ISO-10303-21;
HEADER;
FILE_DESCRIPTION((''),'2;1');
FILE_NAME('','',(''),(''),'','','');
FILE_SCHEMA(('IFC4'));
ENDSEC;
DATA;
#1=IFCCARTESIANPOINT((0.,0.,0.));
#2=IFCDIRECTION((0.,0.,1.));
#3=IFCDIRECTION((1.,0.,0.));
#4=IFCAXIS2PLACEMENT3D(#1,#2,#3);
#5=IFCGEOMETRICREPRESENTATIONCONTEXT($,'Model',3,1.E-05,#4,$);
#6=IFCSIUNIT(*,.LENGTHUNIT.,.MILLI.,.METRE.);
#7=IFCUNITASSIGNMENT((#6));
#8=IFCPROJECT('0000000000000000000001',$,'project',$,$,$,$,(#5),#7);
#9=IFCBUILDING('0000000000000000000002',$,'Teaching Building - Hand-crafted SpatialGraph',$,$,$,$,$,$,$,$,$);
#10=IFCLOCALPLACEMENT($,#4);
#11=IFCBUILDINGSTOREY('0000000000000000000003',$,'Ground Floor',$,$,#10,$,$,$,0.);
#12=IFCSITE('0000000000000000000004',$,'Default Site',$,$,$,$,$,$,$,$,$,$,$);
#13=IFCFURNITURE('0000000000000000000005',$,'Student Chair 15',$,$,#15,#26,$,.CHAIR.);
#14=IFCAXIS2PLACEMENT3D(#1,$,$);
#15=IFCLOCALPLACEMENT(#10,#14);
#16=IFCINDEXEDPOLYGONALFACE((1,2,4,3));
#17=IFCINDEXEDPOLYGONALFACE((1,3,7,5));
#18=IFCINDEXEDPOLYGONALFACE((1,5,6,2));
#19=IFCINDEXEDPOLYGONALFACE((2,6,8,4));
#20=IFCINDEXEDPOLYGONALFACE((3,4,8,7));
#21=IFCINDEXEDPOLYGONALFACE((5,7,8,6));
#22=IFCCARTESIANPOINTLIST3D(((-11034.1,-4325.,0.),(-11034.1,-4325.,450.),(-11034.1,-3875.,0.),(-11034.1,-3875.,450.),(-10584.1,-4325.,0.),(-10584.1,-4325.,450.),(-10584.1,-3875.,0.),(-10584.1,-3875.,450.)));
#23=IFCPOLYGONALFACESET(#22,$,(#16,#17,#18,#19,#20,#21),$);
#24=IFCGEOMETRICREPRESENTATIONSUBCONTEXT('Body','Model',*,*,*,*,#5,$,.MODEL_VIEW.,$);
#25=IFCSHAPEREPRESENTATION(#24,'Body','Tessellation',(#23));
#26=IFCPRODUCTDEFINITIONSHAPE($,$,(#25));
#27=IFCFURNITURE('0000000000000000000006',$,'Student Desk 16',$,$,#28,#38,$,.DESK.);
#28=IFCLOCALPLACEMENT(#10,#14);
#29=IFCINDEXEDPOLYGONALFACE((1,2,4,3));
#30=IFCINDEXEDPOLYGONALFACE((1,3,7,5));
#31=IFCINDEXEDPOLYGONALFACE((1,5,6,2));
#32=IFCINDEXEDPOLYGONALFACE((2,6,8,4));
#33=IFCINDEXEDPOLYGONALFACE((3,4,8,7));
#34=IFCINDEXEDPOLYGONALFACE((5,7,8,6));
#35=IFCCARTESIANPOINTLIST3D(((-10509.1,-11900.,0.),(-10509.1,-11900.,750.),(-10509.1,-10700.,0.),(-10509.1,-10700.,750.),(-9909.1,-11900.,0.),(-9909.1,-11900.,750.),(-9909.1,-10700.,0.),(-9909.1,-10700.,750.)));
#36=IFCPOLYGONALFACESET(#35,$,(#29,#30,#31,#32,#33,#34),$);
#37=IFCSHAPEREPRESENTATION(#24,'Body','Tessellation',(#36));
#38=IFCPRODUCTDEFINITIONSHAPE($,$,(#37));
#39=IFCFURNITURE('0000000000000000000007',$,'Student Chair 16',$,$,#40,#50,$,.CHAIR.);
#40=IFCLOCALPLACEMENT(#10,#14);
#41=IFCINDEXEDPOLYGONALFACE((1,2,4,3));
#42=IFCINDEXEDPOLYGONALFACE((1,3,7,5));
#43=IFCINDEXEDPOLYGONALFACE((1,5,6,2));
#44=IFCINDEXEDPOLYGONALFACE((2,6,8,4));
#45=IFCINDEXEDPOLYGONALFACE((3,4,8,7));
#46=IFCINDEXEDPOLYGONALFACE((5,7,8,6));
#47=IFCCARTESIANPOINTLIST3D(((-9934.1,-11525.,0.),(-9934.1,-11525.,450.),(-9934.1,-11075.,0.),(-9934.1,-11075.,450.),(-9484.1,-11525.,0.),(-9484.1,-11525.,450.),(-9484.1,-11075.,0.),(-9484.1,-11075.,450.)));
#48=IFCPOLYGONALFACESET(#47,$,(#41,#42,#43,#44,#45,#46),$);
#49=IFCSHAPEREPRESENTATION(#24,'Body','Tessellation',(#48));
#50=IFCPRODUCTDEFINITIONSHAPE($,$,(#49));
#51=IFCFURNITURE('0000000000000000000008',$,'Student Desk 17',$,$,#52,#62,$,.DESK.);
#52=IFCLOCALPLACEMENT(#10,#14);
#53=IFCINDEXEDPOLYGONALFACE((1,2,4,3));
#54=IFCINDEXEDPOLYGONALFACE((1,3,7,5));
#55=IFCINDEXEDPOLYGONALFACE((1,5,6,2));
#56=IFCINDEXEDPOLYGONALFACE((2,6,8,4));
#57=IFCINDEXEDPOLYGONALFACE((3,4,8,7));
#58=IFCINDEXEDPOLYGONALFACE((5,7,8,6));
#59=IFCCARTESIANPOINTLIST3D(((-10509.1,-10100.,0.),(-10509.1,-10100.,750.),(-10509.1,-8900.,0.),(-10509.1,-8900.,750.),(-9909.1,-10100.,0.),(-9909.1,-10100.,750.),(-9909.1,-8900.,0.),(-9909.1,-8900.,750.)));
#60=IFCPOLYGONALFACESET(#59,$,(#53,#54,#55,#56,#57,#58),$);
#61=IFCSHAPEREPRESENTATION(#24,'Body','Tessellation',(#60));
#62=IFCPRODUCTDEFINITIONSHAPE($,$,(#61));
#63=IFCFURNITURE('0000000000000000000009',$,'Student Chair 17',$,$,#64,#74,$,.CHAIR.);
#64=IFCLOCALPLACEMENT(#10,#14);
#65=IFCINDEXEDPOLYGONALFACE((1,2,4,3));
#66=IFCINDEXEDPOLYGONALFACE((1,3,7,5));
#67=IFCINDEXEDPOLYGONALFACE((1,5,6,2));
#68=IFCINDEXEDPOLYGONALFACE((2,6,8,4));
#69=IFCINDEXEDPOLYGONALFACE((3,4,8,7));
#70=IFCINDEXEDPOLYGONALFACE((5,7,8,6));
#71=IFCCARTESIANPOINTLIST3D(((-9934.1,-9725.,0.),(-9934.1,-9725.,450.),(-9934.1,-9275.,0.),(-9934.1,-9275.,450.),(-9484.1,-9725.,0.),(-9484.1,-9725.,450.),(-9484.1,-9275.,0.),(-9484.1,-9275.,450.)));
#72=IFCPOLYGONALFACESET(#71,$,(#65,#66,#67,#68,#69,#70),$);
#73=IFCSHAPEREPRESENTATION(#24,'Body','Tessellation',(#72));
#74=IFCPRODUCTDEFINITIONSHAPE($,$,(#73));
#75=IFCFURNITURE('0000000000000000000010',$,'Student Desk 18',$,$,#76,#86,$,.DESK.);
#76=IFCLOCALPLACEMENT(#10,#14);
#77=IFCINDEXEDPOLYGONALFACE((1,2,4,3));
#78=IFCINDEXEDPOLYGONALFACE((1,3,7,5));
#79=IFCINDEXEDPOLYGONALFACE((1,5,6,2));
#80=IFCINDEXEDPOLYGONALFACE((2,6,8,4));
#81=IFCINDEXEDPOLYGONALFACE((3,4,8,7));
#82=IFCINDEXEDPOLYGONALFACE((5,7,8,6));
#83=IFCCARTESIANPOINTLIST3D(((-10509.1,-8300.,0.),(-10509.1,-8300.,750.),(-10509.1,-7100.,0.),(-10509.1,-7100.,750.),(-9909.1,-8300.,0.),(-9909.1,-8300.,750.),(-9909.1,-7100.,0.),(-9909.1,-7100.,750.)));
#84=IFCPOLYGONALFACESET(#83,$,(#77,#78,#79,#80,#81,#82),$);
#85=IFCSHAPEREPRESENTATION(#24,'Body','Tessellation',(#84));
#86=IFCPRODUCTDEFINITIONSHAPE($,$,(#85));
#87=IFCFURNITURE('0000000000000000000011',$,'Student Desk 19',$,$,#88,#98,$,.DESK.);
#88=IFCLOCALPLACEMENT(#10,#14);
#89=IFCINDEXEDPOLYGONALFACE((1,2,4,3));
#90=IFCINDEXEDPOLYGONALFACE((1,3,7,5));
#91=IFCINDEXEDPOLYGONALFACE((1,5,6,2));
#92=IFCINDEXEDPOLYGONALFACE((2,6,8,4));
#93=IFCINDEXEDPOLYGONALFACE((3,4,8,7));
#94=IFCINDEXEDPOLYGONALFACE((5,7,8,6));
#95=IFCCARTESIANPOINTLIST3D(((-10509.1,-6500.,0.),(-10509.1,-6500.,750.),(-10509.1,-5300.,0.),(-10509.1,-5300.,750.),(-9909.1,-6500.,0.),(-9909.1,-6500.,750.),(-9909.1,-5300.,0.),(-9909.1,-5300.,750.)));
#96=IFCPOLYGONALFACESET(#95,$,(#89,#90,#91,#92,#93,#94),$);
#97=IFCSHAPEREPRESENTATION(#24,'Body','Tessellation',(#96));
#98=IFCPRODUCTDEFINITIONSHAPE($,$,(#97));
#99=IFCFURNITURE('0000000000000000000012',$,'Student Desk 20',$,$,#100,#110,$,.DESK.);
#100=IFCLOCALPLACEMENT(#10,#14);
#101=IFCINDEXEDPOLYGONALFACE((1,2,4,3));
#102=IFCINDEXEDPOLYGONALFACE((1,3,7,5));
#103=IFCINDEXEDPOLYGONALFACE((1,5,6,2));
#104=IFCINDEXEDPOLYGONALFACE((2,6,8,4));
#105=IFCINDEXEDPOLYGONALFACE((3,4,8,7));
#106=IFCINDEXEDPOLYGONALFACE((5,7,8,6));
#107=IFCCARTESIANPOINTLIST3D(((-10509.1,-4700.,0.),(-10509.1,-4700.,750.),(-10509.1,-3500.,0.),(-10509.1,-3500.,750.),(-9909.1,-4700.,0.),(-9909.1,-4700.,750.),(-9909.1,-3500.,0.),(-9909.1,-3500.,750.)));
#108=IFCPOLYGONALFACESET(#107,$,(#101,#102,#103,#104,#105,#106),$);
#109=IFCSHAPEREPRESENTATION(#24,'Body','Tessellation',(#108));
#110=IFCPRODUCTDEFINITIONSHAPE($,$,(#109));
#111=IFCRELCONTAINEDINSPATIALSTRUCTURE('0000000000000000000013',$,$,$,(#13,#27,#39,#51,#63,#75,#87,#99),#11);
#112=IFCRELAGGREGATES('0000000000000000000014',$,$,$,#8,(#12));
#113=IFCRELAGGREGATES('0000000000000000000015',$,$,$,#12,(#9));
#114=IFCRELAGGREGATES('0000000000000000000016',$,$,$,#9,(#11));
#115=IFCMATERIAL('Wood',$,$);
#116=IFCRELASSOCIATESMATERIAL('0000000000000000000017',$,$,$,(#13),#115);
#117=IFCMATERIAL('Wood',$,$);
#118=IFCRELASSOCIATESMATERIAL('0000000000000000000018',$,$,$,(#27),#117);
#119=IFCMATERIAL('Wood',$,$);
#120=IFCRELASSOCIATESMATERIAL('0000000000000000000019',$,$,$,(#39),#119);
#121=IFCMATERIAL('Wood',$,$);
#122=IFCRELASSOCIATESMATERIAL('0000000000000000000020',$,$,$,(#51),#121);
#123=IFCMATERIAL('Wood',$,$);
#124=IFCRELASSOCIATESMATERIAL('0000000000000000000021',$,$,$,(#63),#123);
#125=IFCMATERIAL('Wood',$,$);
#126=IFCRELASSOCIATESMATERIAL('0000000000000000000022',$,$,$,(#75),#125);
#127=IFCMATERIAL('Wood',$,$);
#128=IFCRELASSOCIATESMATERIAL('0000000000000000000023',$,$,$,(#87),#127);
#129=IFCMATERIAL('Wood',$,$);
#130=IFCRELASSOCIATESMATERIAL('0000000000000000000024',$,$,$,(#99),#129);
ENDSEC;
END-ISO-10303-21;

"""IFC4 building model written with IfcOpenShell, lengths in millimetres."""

from ifc_helpers import new_model, si_unit, frame, origin_with_axes, origin_2d, place, context, subcontext, project, spatial, rectangle, extrude, material, element, save


model = new_model("IFC4")

# Units and contexts
model_context = context("Model", 3, precision=1e-05, world=origin_with_axes())
body_context = subcontext(model_context, "Body", "Model", "MODEL_VIEW")
ifc_project = project(units=[si_unit("LENGTHUNIT", "METRE", prefix="MILLI")], contexts=[model_context])

# Site, building, storey
site = spatial("IfcSite", under=ifc_project, Name="Default Site")
building = spatial("IfcBuilding", under=site, Name="Teaching Building - Hand-crafted SpatialGraph")
storey_placement = place(None, origin_with_axes())
storey = spatial("IfcBuildingStorey", under=building, at=storey_placement, Name="Ground Floor", Elevation=0.0)

# Furniture
ifc_material_1 = material(Name="Wood")
furniture_1_placement = place(storey_placement, frame((-10809.1, -4100.0, 0.0), z_axis=(0.0, 0.0, 1.0), x_axis=(1.0, 0.0, 0.0)))
element("IfcFurniture", 1, at=furniture_1_placement, inside=storey, material=ifc_material_1, Name="Student Chair 15", PredefinedType="CHAIR", context=body_context, shape_type="SweptSolid", body=[
    extrude(rectangle(XDim=450.0, YDim=450.0, at=origin_2d()), origin_with_axes(), (0.0, 0.0, 1.0), 450.0),
])
ifc_material_2 = material(Name="Wood")
furniture_2_placement = place(storey_placement, frame((-10209.1, -11300.0, 0.0), z_axis=(0.0, 0.0, 1.0), x_axis=(0.0, 1.0, 0.0)))
element("IfcFurniture", 2, at=furniture_2_placement, inside=storey, material=ifc_material_2, Name="Student Desk 16", PredefinedType="DESK", context=body_context, shape_type="SweptSolid", body=[
    extrude(rectangle(XDim=1200.0, YDim=600.0, at=origin_2d()), origin_with_axes(), (0.0, 0.0, 1.0), 750.0),
])
ifc_material_3 = material(Name="Wood")
furniture_3_placement = place(storey_placement, frame((-9709.1, -11300.0, 0.0), z_axis=(0.0, 0.0, 1.0), x_axis=(1.0, 0.0, 0.0)))
element("IfcFurniture", 3, at=furniture_3_placement, inside=storey, material=ifc_material_3, Name="Student Chair 16", PredefinedType="CHAIR", context=body_context, shape_type="SweptSolid", body=[
    extrude(rectangle(XDim=450.0, YDim=450.0, at=origin_2d()), origin_with_axes(), (0.0, 0.0, 1.0), 450.0),
])
ifc_material_4 = material(Name="Wood")
furniture_4_placement = place(storey_placement, frame((-10209.1, -9500.0, 0.0), z_axis=(0.0, 0.0, 1.0), x_axis=(0.0, 1.0, 0.0)))
element("IfcFurniture", 4, at=furniture_4_placement, inside=storey, material=ifc_material_4, Name="Student Desk 17", PredefinedType="DESK", context=body_context, shape_type="SweptSolid", body=[
    extrude(rectangle(XDim=1200.0, YDim=600.0, at=origin_2d()), origin_with_axes(), (0.0, 0.0, 1.0), 750.0),
])
ifc_material_5 = material(Name="Wood")
furniture_5_placement = place(storey_placement, frame((-9709.1, -9500.0, 0.0), z_axis=(0.0, 0.0, 1.0), x_axis=(1.0, 0.0, 0.0)))
element("IfcFurniture", 5, at=furniture_5_placement, inside=storey, material=ifc_material_5, Name="Student Chair 17", PredefinedType="CHAIR", context=body_context, shape_type="SweptSolid", body=[
    extrude(rectangle(XDim=450.0, YDim=450.0, at=origin_2d()), origin_with_axes(), (0.0, 0.0, 1.0), 450.0),
])
ifc_material_6 = material(Name="Wood")
furniture_6_placement = place(storey_placement, frame((-10209.1, -7700.0, 0.0), z_axis=(0.0, 0.0, 1.0), x_axis=(0.0, 1.0, 0.0)))
element("IfcFurniture", 6, at=furniture_6_placement, inside=storey, material=ifc_material_6, Name="Student Desk 18", PredefinedType="DESK", context=body_context, shape_type="SweptSolid", body=[
    extrude(rectangle(XDim=1200.0, YDim=600.0, at=origin_2d()), origin_with_axes(), (0.0, 0.0, 1.0), 750.0),
])
ifc_material_7 = material(Name="Wood")
furniture_7_placement = place(storey_placement, frame((-10209.1, -5900.0, 0.0), z_axis=(0.0, 0.0, 1.0), x_axis=(0.0, 1.0, 0.0)))
element("IfcFurniture", 7, at=furniture_7_placement, inside=storey, material=ifc_material_7, Name="Student Desk 19", PredefinedType="DESK", context=body_context, shape_type="SweptSolid", body=[
    extrude(rectangle(XDim=1200.0, YDim=600.0, at=origin_2d()), origin_with_axes(), (0.0, 0.0, 1.0), 750.0),
])
ifc_material_8 = material(Name="Wood")
furniture_8_placement = place(storey_placement, frame((-10209.1, -4100.0, 0.0), z_axis=(0.0, 0.0, 1.0), x_axis=(0.0, 1.0, 0.0)))
element("IfcFurniture", 8, at=furniture_8_placement, inside=storey, material=ifc_material_8, Name="Student Desk 20", PredefinedType="DESK", context=body_context, shape_type="SweptSolid", body=[
    extrude(rectangle(XDim=1200.0, YDim=600.0, at=origin_2d()), origin_with_axes(), (0.0, 0.0, 1.0), 750.0),
])

save(model, "model.ifc")
